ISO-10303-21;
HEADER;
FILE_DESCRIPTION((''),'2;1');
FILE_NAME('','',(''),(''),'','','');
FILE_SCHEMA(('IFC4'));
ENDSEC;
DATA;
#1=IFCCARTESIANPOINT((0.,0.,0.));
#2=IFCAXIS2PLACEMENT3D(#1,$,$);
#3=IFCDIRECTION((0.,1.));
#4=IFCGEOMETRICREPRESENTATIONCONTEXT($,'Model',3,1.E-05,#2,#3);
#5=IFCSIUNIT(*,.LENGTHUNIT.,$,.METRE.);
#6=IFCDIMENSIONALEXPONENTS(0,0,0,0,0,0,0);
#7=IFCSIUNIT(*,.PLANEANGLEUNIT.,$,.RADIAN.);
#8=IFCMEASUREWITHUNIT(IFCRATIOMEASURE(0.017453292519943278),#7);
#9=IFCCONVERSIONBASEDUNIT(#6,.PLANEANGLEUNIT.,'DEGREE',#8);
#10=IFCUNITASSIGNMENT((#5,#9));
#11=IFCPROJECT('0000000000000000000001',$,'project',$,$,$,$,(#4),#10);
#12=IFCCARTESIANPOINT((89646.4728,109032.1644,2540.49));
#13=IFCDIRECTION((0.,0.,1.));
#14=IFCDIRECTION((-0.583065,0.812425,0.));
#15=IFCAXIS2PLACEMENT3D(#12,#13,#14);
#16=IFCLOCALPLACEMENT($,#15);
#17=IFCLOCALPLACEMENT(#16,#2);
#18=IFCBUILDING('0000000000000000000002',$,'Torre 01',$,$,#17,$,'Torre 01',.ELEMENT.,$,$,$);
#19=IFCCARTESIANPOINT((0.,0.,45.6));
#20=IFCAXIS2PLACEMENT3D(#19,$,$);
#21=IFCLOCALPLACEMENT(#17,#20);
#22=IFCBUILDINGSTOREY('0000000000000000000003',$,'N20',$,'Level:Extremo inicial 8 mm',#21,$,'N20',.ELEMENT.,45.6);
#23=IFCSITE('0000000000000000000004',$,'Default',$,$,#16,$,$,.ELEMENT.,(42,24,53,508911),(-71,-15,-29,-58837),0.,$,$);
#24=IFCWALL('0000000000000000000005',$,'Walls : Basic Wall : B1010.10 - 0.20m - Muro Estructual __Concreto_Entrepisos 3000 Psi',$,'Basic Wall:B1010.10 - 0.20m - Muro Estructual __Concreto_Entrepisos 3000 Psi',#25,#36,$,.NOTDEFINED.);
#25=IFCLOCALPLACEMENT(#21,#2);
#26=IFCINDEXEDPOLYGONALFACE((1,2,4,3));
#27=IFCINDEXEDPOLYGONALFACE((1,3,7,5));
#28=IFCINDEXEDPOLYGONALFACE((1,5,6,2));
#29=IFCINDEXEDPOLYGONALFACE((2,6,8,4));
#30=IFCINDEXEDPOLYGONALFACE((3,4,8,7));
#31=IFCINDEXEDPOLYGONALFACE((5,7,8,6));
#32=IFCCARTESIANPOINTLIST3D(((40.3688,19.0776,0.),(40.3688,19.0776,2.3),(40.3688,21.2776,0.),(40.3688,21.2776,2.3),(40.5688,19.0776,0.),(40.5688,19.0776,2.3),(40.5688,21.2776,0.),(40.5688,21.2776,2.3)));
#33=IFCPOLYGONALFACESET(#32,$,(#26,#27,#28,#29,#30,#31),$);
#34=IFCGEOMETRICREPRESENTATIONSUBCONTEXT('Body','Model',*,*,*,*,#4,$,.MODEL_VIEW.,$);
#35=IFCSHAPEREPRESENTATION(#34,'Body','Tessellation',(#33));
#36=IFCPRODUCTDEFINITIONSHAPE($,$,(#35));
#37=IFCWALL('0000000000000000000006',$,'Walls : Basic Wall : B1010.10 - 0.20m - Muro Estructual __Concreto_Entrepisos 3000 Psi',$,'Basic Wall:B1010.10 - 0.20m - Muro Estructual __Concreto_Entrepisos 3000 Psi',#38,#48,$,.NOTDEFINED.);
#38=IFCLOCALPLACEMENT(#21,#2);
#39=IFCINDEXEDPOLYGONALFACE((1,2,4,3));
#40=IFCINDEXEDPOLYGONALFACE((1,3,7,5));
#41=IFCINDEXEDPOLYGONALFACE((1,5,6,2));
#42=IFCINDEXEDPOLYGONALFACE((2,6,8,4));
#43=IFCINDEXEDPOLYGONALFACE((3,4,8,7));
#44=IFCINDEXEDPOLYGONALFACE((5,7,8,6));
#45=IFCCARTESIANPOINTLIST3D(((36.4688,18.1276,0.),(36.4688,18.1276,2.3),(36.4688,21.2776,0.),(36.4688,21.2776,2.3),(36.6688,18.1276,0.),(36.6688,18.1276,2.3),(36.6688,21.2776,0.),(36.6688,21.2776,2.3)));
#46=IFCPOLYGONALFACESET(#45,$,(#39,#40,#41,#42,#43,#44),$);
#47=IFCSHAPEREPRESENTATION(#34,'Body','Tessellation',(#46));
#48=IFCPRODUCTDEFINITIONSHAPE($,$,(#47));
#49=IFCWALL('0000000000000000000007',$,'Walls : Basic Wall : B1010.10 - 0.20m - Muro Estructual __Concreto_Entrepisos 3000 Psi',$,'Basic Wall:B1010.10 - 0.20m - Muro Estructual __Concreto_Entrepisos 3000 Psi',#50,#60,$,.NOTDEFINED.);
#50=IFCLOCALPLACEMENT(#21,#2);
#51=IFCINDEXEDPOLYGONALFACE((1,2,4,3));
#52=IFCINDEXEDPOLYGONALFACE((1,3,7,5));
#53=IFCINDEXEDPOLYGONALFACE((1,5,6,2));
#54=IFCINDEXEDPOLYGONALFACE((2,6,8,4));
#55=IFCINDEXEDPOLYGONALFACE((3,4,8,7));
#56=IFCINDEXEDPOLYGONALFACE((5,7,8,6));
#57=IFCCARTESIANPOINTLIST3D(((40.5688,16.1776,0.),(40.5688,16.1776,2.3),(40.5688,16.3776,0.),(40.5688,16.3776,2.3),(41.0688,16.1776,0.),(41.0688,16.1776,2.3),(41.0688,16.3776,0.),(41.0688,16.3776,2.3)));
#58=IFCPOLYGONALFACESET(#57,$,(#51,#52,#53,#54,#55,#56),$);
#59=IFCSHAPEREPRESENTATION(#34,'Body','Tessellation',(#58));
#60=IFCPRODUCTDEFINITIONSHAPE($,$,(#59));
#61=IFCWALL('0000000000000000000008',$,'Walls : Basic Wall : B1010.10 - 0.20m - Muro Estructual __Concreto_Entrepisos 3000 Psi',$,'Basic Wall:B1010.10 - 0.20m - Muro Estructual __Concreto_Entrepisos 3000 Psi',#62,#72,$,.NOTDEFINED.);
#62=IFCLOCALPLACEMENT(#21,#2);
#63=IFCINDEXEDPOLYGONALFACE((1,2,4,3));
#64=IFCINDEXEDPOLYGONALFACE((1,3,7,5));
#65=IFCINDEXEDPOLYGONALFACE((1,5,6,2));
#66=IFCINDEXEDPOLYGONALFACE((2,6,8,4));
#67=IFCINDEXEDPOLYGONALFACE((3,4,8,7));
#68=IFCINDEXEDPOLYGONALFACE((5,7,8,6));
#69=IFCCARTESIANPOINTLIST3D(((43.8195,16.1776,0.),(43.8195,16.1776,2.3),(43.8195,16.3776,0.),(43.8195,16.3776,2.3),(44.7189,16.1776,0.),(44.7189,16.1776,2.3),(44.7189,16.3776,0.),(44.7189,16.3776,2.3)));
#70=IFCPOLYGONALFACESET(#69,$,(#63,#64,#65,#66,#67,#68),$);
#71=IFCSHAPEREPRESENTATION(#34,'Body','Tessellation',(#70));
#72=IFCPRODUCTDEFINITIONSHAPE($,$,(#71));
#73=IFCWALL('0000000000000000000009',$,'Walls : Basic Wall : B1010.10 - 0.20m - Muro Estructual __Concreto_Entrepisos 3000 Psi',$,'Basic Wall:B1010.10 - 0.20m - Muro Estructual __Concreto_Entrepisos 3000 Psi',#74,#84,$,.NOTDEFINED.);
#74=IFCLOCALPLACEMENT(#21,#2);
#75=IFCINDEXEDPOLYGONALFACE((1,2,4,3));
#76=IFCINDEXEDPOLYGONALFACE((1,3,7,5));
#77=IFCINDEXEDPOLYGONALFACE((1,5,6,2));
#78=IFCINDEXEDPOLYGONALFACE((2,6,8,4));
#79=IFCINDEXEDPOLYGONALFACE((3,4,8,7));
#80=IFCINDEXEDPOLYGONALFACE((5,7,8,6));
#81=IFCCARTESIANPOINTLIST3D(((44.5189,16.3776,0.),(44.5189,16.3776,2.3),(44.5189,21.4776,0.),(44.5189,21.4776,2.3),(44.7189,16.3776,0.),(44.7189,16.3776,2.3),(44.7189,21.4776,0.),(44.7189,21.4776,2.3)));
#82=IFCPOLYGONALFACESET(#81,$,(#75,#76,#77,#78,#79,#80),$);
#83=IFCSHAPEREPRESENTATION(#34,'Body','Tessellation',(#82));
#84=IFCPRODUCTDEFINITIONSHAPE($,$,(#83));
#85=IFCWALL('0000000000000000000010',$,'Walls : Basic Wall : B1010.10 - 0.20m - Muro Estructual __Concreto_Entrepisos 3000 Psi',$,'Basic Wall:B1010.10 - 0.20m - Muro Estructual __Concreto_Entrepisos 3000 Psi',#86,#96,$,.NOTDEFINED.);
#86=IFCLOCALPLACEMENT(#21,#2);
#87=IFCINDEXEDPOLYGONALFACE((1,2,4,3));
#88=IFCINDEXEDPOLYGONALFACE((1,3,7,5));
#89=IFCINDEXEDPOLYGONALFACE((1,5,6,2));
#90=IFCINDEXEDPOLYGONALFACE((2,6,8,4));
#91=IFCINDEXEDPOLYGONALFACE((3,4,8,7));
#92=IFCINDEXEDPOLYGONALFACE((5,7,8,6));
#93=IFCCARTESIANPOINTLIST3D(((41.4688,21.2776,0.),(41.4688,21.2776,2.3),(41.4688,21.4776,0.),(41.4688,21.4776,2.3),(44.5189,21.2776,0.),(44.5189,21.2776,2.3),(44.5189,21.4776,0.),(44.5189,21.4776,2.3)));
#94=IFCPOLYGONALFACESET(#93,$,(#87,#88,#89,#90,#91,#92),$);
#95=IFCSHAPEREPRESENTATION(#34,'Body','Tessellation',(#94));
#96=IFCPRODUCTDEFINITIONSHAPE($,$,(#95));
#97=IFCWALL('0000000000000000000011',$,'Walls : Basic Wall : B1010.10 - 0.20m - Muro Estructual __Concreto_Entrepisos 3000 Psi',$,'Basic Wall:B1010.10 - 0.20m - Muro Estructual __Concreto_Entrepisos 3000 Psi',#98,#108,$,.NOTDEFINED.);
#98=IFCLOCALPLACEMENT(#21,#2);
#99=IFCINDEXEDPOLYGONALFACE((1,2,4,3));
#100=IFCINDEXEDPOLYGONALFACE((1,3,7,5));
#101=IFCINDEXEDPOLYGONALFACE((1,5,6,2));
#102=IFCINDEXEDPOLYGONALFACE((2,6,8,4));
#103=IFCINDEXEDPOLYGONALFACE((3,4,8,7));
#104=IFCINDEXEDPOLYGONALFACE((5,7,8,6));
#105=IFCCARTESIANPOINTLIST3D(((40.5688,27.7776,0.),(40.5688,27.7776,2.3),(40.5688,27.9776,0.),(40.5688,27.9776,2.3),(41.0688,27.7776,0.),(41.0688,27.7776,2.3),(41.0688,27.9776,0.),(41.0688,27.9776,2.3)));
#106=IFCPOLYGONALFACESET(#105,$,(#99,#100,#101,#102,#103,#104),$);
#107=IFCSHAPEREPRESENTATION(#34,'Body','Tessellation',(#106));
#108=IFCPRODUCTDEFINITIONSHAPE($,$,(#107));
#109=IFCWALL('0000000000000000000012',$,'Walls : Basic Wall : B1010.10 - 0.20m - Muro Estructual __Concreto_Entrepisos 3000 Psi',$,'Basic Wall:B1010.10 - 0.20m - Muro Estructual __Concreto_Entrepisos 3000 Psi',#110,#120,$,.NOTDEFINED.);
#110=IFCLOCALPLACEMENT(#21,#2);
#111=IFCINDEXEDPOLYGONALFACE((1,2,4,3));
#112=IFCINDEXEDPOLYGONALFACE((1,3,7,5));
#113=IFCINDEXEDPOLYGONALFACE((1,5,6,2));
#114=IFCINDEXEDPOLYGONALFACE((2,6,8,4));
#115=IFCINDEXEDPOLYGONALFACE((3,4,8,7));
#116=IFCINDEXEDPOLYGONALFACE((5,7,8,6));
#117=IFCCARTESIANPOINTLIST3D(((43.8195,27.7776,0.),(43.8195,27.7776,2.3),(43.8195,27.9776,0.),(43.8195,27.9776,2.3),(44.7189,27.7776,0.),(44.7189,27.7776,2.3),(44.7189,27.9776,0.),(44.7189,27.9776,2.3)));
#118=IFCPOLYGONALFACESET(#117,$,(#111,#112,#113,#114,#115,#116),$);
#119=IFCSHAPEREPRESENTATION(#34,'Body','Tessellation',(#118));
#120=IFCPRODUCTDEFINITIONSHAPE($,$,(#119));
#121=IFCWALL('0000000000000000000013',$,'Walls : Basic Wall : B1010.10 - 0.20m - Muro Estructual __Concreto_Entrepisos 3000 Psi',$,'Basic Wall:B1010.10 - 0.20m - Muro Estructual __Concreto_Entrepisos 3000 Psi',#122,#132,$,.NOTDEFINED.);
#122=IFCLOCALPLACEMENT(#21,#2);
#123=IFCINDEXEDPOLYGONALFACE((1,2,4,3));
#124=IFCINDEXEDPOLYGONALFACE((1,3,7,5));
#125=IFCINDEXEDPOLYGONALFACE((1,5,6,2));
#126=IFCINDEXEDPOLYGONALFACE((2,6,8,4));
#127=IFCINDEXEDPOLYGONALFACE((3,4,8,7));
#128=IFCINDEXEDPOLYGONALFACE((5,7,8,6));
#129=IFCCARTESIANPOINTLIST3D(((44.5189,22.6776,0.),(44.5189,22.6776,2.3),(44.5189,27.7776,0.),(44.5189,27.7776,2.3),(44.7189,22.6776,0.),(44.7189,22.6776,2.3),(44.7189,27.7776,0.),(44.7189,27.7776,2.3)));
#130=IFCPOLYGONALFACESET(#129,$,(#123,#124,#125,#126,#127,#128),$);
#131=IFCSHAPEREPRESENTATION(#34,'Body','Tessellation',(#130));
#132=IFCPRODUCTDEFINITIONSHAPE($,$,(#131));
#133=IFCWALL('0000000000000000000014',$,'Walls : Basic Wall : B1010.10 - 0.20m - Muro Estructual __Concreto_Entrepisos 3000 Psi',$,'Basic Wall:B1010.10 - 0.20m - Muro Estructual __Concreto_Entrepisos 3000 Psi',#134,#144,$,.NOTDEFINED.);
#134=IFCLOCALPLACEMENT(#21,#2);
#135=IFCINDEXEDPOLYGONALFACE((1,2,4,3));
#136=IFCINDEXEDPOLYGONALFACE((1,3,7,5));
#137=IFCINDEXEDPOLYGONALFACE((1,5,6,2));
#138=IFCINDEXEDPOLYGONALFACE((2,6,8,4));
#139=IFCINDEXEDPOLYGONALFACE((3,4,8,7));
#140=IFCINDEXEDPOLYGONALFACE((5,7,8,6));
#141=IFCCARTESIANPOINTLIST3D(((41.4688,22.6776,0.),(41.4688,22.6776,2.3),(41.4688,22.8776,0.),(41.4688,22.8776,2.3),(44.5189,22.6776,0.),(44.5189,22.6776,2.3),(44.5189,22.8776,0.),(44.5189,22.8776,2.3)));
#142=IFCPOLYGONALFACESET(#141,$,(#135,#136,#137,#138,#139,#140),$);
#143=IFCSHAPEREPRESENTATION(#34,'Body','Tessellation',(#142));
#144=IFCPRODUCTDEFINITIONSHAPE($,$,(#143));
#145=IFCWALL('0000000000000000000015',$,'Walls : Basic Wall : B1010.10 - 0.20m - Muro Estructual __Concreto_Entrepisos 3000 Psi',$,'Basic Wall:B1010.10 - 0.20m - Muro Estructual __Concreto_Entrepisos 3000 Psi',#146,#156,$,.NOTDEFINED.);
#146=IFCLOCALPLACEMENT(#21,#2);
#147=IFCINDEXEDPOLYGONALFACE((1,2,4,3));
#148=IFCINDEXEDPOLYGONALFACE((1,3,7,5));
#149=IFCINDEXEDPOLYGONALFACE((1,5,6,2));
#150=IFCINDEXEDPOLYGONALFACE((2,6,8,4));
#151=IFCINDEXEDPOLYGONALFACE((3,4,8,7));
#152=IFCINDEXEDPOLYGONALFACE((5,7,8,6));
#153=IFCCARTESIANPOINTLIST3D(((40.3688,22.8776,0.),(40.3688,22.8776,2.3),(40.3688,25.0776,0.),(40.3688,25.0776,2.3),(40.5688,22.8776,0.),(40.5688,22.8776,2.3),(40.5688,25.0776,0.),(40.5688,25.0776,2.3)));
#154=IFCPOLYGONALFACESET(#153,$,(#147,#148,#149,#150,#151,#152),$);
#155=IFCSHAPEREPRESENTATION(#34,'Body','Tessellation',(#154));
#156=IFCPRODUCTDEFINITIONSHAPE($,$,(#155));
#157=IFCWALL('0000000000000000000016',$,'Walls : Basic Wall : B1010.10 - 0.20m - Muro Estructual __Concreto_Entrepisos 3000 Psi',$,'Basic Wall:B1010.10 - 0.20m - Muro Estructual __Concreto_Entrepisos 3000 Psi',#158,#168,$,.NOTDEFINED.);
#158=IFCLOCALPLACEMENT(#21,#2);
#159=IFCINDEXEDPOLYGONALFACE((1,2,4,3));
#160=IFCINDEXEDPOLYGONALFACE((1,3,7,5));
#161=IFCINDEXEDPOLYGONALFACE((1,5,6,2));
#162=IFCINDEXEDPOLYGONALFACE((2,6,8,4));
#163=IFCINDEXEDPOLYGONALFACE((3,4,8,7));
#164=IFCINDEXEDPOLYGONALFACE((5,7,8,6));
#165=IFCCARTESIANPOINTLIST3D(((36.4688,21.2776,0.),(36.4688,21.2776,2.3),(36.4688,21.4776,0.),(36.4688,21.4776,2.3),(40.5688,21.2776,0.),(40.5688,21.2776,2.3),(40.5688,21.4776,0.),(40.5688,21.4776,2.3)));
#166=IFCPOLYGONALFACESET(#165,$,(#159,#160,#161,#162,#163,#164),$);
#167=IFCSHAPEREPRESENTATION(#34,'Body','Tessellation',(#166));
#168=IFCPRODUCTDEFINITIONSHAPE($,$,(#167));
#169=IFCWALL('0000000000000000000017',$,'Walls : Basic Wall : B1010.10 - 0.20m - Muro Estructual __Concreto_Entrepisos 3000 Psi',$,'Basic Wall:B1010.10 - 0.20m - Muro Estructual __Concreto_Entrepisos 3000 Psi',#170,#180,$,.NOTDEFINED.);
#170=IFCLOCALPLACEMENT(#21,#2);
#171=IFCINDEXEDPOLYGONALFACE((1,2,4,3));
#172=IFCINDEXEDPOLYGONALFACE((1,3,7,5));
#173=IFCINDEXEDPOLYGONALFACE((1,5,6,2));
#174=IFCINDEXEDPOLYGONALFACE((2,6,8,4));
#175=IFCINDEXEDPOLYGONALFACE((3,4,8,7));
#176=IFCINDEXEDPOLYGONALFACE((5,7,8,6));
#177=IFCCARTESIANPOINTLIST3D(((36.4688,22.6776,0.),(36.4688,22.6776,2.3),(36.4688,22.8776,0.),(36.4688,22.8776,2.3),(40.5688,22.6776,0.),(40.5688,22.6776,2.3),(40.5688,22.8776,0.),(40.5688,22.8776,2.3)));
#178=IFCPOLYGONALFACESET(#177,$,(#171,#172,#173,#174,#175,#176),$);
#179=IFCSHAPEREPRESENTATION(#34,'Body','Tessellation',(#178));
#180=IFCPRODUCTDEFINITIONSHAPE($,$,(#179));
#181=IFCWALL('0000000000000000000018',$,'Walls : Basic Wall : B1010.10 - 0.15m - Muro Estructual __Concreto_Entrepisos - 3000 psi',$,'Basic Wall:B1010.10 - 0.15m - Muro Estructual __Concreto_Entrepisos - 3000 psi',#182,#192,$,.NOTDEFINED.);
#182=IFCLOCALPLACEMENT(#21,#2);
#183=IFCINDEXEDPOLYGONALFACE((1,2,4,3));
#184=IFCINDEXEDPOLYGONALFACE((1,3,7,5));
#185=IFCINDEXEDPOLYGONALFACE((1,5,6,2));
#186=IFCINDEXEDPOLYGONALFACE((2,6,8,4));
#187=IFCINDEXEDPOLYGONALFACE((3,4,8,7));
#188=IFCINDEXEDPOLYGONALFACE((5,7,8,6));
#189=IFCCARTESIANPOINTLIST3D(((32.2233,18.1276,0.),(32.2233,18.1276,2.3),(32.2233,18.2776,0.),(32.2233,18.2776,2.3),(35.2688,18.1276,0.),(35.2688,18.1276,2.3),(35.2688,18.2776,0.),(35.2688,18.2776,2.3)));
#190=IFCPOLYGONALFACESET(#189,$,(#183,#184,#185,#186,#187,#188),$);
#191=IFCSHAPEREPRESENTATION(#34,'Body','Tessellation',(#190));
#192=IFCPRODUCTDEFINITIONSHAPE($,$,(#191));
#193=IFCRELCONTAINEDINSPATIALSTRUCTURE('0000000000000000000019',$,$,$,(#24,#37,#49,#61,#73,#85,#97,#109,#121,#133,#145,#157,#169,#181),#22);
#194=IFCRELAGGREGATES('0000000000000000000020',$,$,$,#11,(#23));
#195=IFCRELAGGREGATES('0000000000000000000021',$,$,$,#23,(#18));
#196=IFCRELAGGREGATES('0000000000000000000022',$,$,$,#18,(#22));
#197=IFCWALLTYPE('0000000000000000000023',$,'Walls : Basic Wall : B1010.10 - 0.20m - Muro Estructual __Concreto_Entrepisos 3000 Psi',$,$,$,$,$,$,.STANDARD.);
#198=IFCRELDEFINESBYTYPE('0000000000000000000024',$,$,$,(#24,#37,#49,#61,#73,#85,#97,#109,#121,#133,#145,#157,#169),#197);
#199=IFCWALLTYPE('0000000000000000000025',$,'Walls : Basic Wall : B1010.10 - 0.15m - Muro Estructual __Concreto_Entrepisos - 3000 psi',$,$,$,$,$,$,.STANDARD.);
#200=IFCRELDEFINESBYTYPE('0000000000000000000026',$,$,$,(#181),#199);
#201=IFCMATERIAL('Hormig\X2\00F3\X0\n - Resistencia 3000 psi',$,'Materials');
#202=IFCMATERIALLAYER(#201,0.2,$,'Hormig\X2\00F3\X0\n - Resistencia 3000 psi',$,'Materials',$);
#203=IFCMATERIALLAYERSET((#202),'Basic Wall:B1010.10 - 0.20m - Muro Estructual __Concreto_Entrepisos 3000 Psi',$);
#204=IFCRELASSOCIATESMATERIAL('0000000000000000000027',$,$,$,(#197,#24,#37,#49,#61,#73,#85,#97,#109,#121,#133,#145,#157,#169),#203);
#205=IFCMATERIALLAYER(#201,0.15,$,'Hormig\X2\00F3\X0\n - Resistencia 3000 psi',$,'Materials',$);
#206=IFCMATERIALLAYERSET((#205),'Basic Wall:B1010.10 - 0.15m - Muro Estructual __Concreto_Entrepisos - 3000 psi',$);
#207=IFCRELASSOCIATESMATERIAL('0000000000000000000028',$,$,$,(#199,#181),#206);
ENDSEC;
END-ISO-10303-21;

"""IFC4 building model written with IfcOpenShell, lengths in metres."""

from ifc_helpers import new_model, entity, si_unit, converted_unit, direction, frame, frame_2d, origin, place, context, subcontext, project, spatial, rectangle, extrude, material, layer, layer_set, layer_usage, type_object, element, save


model = new_model("IFC4")

# Units and contexts
model_context = context("Model", 3, precision=1e-05, world=origin(), true_north=direction((0.0, 1.0)))
body_context = subcontext(model_context, "Body", "Model", "MODEL_VIEW")
ifc_project = project(units=[si_unit("LENGTHUNIT", "METRE"), converted_unit("PLANEANGLEUNIT", "DEGREE", entity("IfcRatioMeasure", 0.017453292519943278), si_unit("PLANEANGLEUNIT", "RADIAN"), dimensions=[0, 0, 0, 0, 0, 0, 0])], contexts=[model_context])

# Site, building, storey
site_placement = place(None, frame((89646.4728, 109032.1644, 2540.49), z_axis=(0.0, 0.0, 1.0), x_axis=(-0.583065, 0.812425, 0.0)))
site = spatial("IfcSite", under=ifc_project, at=site_placement, Name="Default", CompositionType="ELEMENT", RefLatitude=(42, 24, 53, 508911), RefLongitude=(-71, -15, -29, -58837), RefElevation=0.0)
building_placement = place(site_placement, origin())
building = spatial("IfcBuilding", under=site, at=building_placement, Name="Torre 01", LongName="Torre 01", CompositionType="ELEMENT")
storey_placement = place(building_placement, frame((0.0, 0.0, 45.6)))
storey = spatial("IfcBuildingStorey", under=building, at=storey_placement, Name="N20", ObjectType="Level:Extremo inicial 8 mm", LongName="N20", CompositionType="ELEMENT", Elevation=45.6)

# Walls
ifc_material = material(Name="Hormigón - Resistencia 3000 psi", Category="Materials")
ifc_layer_1 = layer(ifc_material, 0.2, Name="Hormigón - Resistencia 3000 psi", Category="Materials")
ifc_layer_set_1 = layer_set([ifc_layer_1], Name="Basic Wall:B1010.10 - 0.20m - Muro Estructual __Concreto_Entrepisos 3000 Psi")
ifc_layer_usage_1 = layer_usage(ifc_layer_set_1, "AXIS2", "NEGATIVE", 0.1)
wall_type_1 = type_object("IfcWallType", Name="Walls : Basic Wall : B1010.10 - 0.20m - Muro Estructual __Concreto_Entrepisos 3000 Psi", PredefinedType="STANDARD", material=ifc_layer_set_1)
wall_1_placement = place(storey_placement, frame((40.4688, 21.2776, 0.0), z_axis=(0.0, 0.0, 1.0), x_axis=(0.0, -1.0, 0.0)))
element("IfcWall", 1, at=wall_1_placement, inside=storey, type_object=wall_type_1, material=ifc_layer_usage_1, Name="Walls : Basic Wall : B1010.10 - 0.20m - Muro Estructual __Concreto_Entrepisos 3000 Psi", ObjectType="Basic Wall:B1010.10 - 0.20m - Muro Estructual __Concreto_Entrepisos 3000 Psi", PredefinedType="NOTDEFINED", context=body_context, shape_type="SweptSolid", body=[
    extrude(rectangle(XDim=2.2, YDim=0.2, at=frame_2d((1.1, 0.0), x_axis=(-1.0, 0.0))), origin(), (0.0, 0.0, 1.0), 2.3),
])
ifc_layer_usage_2 = layer_usage(ifc_layer_set_1, "AXIS2", "NEGATIVE", 0.1)
wall_2_placement = place(storey_placement, frame((36.5688, 18.1276, 0.0), z_axis=(0.0, 0.0, 1.0), x_axis=(0.0, 1.0, 0.0)))
element("IfcWall", 2, at=wall_2_placement, inside=storey, type_object=wall_type_1, material=ifc_layer_usage_2, Name="Walls : Basic Wall : B1010.10 - 0.20m - Muro Estructual __Concreto_Entrepisos 3000 Psi", ObjectType="Basic Wall:B1010.10 - 0.20m - Muro Estructual __Concreto_Entrepisos 3000 Psi", PredefinedType="NOTDEFINED", context=body_context, shape_type="SweptSolid", body=[
    extrude(rectangle(XDim=3.15, YDim=0.2, at=frame_2d((1.575, 0.0), x_axis=(-1.0, 0.0))), origin(), (0.0, 0.0, 1.0), 2.3),
])
ifc_layer_usage_3 = layer_usage(ifc_layer_set_1, "AXIS2", "NEGATIVE", 0.1)
wall_3_placement = place(storey_placement, frame((41.0688, 16.2776, 0.0), z_axis=(0.0, 0.0, 1.0), x_axis=(-1.0, 0.0, 0.0)))
element("IfcWall", 3, at=wall_3_placement, inside=storey, type_object=wall_type_1, material=ifc_layer_usage_3, Name="Walls : Basic Wall : B1010.10 - 0.20m - Muro Estructual __Concreto_Entrepisos 3000 Psi", ObjectType="Basic Wall:B1010.10 - 0.20m - Muro Estructual __Concreto_Entrepisos 3000 Psi", PredefinedType="NOTDEFINED", context=body_context, shape_type="SweptSolid", body=[
    extrude(rectangle(XDim=0.5, YDim=0.2, at=frame_2d((0.25, 0.0), x_axis=(-1.0, 0.0))), origin(), (0.0, 0.0, 1.0), 2.3),
])
ifc_layer_usage_4 = layer_usage(ifc_layer_set_1, "AXIS2", "NEGATIVE", 0.1)
wall_4_placement = place(storey_placement, frame((43.8195, 16.2776, 0.0)))
element("IfcWall", 4, at=wall_4_placement, inside=storey, type_object=wall_type_1, material=ifc_layer_usage_4, Name="Walls : Basic Wall : B1010.10 - 0.20m - Muro Estructual __Concreto_Entrepisos 3000 Psi", ObjectType="Basic Wall:B1010.10 - 0.20m - Muro Estructual __Concreto_Entrepisos 3000 Psi", PredefinedType="NOTDEFINED", context=body_context, shape_type="SweptSolid", body=[
    extrude(rectangle(XDim=0.8993, YDim=0.2, at=frame_2d((0.4497, 0.0), x_axis=(-1.0, 0.0))), origin(), (0.0, 0.0, 1.0), 2.3),
])
ifc_layer_usage_5 = layer_usage(ifc_layer_set_1, "AXIS2", "NEGATIVE", 0.1)
wall_5_placement = place(storey_placement, frame((44.6189, 21.4776, 0.0), z_axis=(0.0, 0.0, 1.0), x_axis=(0.0, -1.0, 0.0)))
element("IfcWall", 5, at=wall_5_placement, inside=storey, type_object=wall_type_1, material=ifc_layer_usage_5, Name="Walls : Basic Wall : B1010.10 - 0.20m - Muro Estructual __Concreto_Entrepisos 3000 Psi", ObjectType="Basic Wall:B1010.10 - 0.20m - Muro Estructual __Concreto_Entrepisos 3000 Psi", PredefinedType="NOTDEFINED", context=body_context, shape_type="SweptSolid", body=[
    extrude(rectangle(XDim=5.1, YDim=0.2, at=frame_2d((2.55, 0.0), x_axis=(-1.0, 0.0))), origin(), (0.0, 0.0, 1.0), 2.3),
])
ifc_layer_usage_6 = layer_usage(ifc_layer_set_1, "AXIS2", "NEGATIVE", 0.1)
wall_6_placement = place(storey_placement, frame((41.4688, 21.3776, 0.0)))
element("IfcWall", 6, at=wall_6_placement, inside=storey, type_object=wall_type_1, material=ifc_layer_usage_6, Name="Walls : Basic Wall : B1010.10 - 0.20m - Muro Estructual __Concreto_Entrepisos 3000 Psi", ObjectType="Basic Wall:B1010.10 - 0.20m - Muro Estructual __Concreto_Entrepisos 3000 Psi", PredefinedType="NOTDEFINED", context=body_context, shape_type="SweptSolid", body=[
    extrude(rectangle(XDim=3.05, YDim=0.2, at=frame_2d((1.525, 0.0), x_axis=(-1.0, 0.0))), origin(), (0.0, 0.0, 1.0), 2.3),
])
ifc_layer_usage_7 = layer_usage(ifc_layer_set_1, "AXIS2", "POSITIVE", -0.1)
wall_7_placement = place(storey_placement, frame((41.0688, 27.8776, 0.0), z_axis=(0.0, 0.0, 1.0), x_axis=(-1.0, 0.0, 0.0)))
element("IfcWall", 7, at=wall_7_placement, inside=storey, type_object=wall_type_1, material=ifc_layer_usage_7, Name="Walls : Basic Wall : B1010.10 - 0.20m - Muro Estructual __Concreto_Entrepisos 3000 Psi", ObjectType="Basic Wall:B1010.10 - 0.20m - Muro Estructual __Concreto_Entrepisos 3000 Psi", PredefinedType="NOTDEFINED", context=body_context, shape_type="SweptSolid", body=[
    extrude(rectangle(XDim=0.5, YDim=0.2, at=frame_2d((0.25, 0.0), x_axis=(-1.0, 0.0))), origin(), (0.0, 0.0, 1.0), 2.3),
])
ifc_layer_usage_8 = layer_usage(ifc_layer_set_1, "AXIS2", "POSITIVE", -0.1)
wall_8_placement = place(storey_placement, frame((43.8195, 27.8776, 0.0)))
element("IfcWall", 8, at=wall_8_placement, inside=storey, type_object=wall_type_1, material=ifc_layer_usage_8, Name="Walls : Basic Wall : B1010.10 - 0.20m - Muro Estructual __Concreto_Entrepisos 3000 Psi", ObjectType="Basic Wall:B1010.10 - 0.20m - Muro Estructual __Concreto_Entrepisos 3000 Psi", PredefinedType="NOTDEFINED", context=body_context, shape_type="SweptSolid", body=[
    extrude(rectangle(XDim=0.8993, YDim=0.2, at=frame_2d((0.4497, 0.0), x_axis=(-1.0, 0.0))), origin(), (0.0, 0.0, 1.0), 2.3),
])
ifc_layer_usage_9 = layer_usage(ifc_layer_set_1, "AXIS2", "POSITIVE", -0.1)
wall_9_placement = place(storey_placement, frame((44.6189, 22.6776, 0.0), z_axis=(0.0, 0.0, 1.0), x_axis=(0.0, 1.0, 0.0)))
element("IfcWall", 9, at=wall_9_placement, inside=storey, type_object=wall_type_1, material=ifc_layer_usage_9, Name="Walls : Basic Wall : B1010.10 - 0.20m - Muro Estructual __Concreto_Entrepisos 3000 Psi", ObjectType="Basic Wall:B1010.10 - 0.20m - Muro Estructual __Concreto_Entrepisos 3000 Psi", PredefinedType="NOTDEFINED", context=body_context, shape_type="SweptSolid", body=[
    extrude(rectangle(XDim=5.1, YDim=0.2, at=frame_2d((2.55, 0.0), x_axis=(-1.0, 0.0))), origin(), (0.0, 0.0, 1.0), 2.3),
])
ifc_layer_usage_10 = layer_usage(ifc_layer_set_1, "AXIS2", "POSITIVE", -0.1)
wall_10_placement = place(storey_placement, frame((41.4688, 22.7776, 0.0)))
element("IfcWall", 10, at=wall_10_placement, inside=storey, type_object=wall_type_1, material=ifc_layer_usage_10, Name="Walls : Basic Wall : B1010.10 - 0.20m - Muro Estructual __Concreto_Entrepisos 3000 Psi", ObjectType="Basic Wall:B1010.10 - 0.20m - Muro Estructual __Concreto_Entrepisos 3000 Psi", PredefinedType="NOTDEFINED", context=body_context, shape_type="SweptSolid", body=[
    extrude(rectangle(XDim=3.05, YDim=0.2, at=frame_2d((1.525, 0.0), x_axis=(-1.0, 0.0))), origin(), (0.0, 0.0, 1.0), 2.3),
])
ifc_layer_usage_11 = layer_usage(ifc_layer_set_1, "AXIS2", "POSITIVE", -0.1)
wall_11_placement = place(storey_placement, frame((40.4688, 22.8776, 0.0), z_axis=(0.0, 0.0, 1.0), x_axis=(0.0, 1.0, 0.0)))
element("IfcWall", 11, at=wall_11_placement, inside=storey, type_object=wall_type_1, material=ifc_layer_usage_11, Name="Walls : Basic Wall : B1010.10 - 0.20m - Muro Estructual __Concreto_Entrepisos 3000 Psi", ObjectType="Basic Wall:B1010.10 - 0.20m - Muro Estructual __Concreto_Entrepisos 3000 Psi", PredefinedType="NOTDEFINED", context=body_context, shape_type="SweptSolid", body=[
    extrude(rectangle(XDim=2.2, YDim=0.2, at=frame_2d((1.1, 0.0), x_axis=(-1.0, 0.0))), origin(), (0.0, 0.0, 1.0), 2.3),
])
ifc_layer_usage_12 = layer_usage(ifc_layer_set_1, "AXIS2", "NEGATIVE", 0.1)
wall_12_placement = place(storey_placement, frame((36.4688, 21.3776, 0.0)))
element("IfcWall", 12, at=wall_12_placement, inside=storey, type_object=wall_type_1, material=ifc_layer_usage_12, Name="Walls : Basic Wall : B1010.10 - 0.20m - Muro Estructual __Concreto_Entrepisos 3000 Psi", ObjectType="Basic Wall:B1010.10 - 0.20m - Muro Estructual __Concreto_Entrepisos 3000 Psi", PredefinedType="NOTDEFINED", context=body_context, shape_type="SweptSolid", body=[
    extrude(rectangle(XDim=4.1, YDim=0.2, at=frame_2d((2.05, 0.0), x_axis=(-1.0, 0.0))), origin(), (0.0, 0.0, 1.0), 2.3),
])
ifc_layer_usage_13 = layer_usage(ifc_layer_set_1, "AXIS2", "POSITIVE", -0.1)
wall_13_placement = place(storey_placement, frame((36.4688, 22.7776, 0.0)))
element("IfcWall", 13, at=wall_13_placement, inside=storey, type_object=wall_type_1, material=ifc_layer_usage_13, Name="Walls : Basic Wall : B1010.10 - 0.20m - Muro Estructual __Concreto_Entrepisos 3000 Psi", ObjectType="Basic Wall:B1010.10 - 0.20m - Muro Estructual __Concreto_Entrepisos 3000 Psi", PredefinedType="NOTDEFINED", context=body_context, shape_type="SweptSolid", body=[
    extrude(rectangle(XDim=4.1, YDim=0.2, at=frame_2d((2.05, 0.0), x_axis=(-1.0, 0.0))), origin(), (0.0, 0.0, 1.0), 2.3),
])
ifc_layer_2 = layer(ifc_material, 0.15, Name="Hormigón - Resistencia 3000 psi", Category="Materials")
ifc_layer_set_2 = layer_set([ifc_layer_2], Name="Basic Wall:B1010.10 - 0.15m - Muro Estructual __Concreto_Entrepisos - 3000 psi")
ifc_layer_usage_14 = layer_usage(ifc_layer_set_2, "AXIS2", "NEGATIVE", 0.075)
wall_type_2 = type_object("IfcWallType", Name="Walls : Basic Wall : B1010.10 - 0.15m - Muro Estructual __Concreto_Entrepisos - 3000 psi", PredefinedType="STANDARD", material=ifc_layer_set_2)
wall_14_placement = place(storey_placement, frame((32.2233, 18.2026, 0.0)))
element("IfcWall", 14, at=wall_14_placement, inside=storey, type_object=wall_type_2, material=ifc_layer_usage_14, Name="Walls : Basic Wall : B1010.10 - 0.15m - Muro Estructual __Concreto_Entrepisos - 3000 psi", ObjectType="Basic Wall:B1010.10 - 0.15m - Muro Estructual __Concreto_Entrepisos - 3000 psi", PredefinedType="NOTDEFINED", context=body_context, shape_type="SweptSolid", body=[
    extrude(rectangle(XDim=3.0455, YDim=0.15, at=frame_2d((1.5228, 0.0), x_axis=(-1.0, 0.0))), origin(), (0.0, 0.0, 1.0), 2.3),
])

save(model, "model.ifc")
